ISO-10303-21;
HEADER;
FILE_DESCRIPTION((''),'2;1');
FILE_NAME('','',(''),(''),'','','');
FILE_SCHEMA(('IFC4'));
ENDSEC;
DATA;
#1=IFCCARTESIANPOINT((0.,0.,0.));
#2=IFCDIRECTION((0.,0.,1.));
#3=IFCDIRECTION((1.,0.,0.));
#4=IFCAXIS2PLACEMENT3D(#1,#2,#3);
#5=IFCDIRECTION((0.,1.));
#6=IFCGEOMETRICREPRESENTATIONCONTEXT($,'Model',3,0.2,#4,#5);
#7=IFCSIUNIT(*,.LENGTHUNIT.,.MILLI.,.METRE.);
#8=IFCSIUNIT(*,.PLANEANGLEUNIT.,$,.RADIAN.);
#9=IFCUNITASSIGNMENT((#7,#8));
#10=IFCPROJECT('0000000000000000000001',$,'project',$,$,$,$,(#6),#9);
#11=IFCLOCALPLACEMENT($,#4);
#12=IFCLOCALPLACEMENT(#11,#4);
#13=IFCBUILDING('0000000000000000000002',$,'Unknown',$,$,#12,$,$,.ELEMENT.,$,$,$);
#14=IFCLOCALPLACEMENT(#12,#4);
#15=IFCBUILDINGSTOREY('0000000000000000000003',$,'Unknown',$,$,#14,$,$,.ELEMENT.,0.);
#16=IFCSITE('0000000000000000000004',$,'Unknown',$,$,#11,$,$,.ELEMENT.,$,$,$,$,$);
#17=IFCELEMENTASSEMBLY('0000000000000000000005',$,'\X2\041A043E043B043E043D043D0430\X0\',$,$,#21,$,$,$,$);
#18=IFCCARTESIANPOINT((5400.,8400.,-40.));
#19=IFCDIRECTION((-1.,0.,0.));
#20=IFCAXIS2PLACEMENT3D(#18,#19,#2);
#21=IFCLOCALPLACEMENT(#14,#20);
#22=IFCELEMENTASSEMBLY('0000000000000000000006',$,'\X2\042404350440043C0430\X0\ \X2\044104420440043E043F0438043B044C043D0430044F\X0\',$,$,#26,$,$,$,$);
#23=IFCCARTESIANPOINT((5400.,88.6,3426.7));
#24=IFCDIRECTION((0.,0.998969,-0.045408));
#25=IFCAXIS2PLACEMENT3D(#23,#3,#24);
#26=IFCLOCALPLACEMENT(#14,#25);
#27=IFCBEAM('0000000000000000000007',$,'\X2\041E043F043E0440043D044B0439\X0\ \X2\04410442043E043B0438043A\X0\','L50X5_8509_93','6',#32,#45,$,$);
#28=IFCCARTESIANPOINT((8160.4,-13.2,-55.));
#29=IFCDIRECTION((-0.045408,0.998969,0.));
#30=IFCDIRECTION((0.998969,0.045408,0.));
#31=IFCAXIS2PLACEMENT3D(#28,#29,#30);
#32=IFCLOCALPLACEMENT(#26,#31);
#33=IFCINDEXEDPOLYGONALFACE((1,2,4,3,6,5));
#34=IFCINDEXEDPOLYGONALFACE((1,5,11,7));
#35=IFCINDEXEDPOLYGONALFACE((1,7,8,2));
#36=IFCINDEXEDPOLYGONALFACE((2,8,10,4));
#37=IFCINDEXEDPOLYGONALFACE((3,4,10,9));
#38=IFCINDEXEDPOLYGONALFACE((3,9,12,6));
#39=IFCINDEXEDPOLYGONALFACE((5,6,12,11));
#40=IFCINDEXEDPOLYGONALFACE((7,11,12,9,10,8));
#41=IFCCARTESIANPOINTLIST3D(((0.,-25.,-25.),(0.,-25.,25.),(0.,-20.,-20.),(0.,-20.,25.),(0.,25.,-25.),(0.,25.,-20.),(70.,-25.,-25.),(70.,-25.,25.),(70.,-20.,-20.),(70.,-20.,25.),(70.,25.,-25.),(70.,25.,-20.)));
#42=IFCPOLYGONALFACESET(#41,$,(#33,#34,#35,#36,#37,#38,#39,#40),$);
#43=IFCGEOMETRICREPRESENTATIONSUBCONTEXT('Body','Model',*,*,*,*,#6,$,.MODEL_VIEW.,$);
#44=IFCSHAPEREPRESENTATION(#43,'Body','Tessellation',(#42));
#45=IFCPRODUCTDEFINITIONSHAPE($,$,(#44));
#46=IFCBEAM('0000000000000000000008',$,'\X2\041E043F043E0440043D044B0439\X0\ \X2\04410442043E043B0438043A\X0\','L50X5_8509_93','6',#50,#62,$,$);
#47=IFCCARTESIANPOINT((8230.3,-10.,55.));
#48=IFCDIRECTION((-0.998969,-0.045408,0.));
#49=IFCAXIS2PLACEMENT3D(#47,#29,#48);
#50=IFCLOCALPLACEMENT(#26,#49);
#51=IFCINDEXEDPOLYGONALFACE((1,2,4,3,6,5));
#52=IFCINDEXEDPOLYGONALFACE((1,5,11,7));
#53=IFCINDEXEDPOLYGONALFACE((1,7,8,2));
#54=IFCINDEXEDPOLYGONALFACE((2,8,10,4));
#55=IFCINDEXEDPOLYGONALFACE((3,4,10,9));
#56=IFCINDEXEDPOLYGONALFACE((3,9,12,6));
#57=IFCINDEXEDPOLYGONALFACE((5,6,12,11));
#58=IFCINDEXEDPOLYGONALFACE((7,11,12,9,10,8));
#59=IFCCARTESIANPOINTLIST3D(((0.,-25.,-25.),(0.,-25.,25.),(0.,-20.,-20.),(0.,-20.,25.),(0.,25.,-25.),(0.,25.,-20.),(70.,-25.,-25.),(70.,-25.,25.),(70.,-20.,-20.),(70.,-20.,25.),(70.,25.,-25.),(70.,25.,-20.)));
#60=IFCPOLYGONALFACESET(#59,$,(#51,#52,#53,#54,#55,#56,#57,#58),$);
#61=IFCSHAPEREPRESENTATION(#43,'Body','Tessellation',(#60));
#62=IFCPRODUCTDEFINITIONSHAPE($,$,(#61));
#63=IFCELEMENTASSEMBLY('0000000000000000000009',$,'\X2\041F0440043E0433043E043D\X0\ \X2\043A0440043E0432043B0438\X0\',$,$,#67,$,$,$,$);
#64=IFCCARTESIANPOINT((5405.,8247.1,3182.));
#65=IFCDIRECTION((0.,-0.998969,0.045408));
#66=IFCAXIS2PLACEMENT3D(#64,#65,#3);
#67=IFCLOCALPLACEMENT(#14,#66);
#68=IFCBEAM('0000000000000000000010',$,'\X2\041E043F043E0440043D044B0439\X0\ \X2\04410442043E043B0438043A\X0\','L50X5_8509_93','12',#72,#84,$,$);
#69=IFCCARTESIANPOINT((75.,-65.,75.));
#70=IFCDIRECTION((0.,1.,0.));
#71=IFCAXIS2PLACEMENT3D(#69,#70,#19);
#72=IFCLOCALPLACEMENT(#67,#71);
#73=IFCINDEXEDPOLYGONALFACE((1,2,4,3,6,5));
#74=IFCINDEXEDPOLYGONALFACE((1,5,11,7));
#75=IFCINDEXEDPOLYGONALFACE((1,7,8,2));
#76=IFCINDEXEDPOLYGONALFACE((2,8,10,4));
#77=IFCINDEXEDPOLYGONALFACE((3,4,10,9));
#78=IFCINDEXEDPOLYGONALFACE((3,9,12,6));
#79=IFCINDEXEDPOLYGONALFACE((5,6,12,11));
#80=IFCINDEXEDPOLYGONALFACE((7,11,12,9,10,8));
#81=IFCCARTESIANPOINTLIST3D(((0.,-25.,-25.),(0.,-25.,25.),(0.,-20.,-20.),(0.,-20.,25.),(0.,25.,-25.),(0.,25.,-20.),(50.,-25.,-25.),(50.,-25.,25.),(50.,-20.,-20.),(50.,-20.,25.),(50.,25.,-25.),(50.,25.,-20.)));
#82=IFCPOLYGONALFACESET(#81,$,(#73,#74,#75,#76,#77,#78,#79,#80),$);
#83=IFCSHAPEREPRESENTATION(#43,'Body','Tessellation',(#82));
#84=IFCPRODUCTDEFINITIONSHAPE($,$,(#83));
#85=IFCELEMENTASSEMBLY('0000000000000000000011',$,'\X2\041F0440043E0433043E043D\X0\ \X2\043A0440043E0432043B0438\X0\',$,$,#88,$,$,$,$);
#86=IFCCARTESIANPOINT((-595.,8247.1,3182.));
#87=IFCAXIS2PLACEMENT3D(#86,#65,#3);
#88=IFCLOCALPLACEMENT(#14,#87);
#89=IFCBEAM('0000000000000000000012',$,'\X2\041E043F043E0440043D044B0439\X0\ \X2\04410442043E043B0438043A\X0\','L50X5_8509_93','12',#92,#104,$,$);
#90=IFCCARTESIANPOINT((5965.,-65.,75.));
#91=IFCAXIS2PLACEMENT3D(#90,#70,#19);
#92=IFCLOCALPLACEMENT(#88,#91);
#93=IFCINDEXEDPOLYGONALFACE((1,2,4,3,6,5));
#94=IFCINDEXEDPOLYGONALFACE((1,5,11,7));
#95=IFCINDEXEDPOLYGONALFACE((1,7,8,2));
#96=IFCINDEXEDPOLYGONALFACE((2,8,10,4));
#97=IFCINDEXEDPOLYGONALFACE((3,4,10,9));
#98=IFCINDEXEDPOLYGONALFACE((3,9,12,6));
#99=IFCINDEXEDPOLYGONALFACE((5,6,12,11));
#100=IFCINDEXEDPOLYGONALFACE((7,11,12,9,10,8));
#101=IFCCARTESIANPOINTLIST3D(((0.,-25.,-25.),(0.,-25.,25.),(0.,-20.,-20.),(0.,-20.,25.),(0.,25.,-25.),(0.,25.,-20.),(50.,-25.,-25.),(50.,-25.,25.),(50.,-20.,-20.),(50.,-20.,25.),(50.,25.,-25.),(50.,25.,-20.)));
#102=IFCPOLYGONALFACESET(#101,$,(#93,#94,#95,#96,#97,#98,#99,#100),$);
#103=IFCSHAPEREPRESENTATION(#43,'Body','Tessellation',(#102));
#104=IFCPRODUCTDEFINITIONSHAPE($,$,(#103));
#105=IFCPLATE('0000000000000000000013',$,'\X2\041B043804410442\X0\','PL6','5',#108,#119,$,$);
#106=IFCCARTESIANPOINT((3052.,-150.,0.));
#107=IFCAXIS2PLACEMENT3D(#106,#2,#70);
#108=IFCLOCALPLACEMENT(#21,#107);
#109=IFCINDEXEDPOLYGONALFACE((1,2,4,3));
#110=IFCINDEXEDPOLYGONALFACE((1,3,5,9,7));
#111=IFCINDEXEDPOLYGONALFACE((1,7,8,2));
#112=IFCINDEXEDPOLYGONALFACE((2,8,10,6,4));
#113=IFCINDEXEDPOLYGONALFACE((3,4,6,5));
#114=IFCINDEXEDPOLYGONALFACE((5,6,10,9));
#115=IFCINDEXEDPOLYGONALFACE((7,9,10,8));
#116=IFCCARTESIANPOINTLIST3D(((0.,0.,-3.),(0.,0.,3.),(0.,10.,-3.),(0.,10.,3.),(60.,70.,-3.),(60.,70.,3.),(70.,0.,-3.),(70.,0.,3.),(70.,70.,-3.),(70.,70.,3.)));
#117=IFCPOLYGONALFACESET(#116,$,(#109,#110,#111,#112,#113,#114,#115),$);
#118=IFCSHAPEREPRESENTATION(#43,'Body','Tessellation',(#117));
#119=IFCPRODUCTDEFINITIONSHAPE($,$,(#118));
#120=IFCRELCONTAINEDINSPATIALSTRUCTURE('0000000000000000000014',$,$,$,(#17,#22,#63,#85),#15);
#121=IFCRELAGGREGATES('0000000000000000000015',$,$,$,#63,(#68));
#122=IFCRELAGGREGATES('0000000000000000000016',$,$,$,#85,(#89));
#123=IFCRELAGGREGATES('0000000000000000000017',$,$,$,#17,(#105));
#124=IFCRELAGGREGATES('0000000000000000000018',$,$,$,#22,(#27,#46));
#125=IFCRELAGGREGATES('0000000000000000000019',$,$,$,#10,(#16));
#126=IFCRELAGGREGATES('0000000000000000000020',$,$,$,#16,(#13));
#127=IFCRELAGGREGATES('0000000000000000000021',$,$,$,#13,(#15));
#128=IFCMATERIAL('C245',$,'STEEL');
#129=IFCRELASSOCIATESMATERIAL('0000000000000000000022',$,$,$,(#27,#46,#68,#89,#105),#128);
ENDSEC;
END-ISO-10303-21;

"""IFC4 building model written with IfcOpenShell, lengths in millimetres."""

from ifc_helpers import new_model, si_unit, direction, frame, origin_with_axes, place, context, subcontext, project, spatial, line, indexed_curve, outline, extrude, material, element, aggregate, save


model = new_model("IFC4")

# Units and contexts
model_context = context("Model", 3, precision=0.2, world=origin_with_axes(), true_north=direction((0.0, 1.0)))
body_context = subcontext(model_context, "Body", "Model", "MODEL_VIEW")
ifc_project = project(units=[si_unit("LENGTHUNIT", "METRE", prefix="MILLI"), si_unit("PLANEANGLEUNIT", "RADIAN")], contexts=[model_context])

# Site, building, storey
site_placement = place(None, origin_with_axes())
site = spatial("IfcSite", under=ifc_project, at=site_placement, Name="Unknown", CompositionType="ELEMENT")
building_placement = place(site_placement, origin_with_axes())
building = spatial("IfcBuilding", under=site, at=building_placement, Name="Unknown", CompositionType="ELEMENT")
storey_placement = place(building_placement, origin_with_axes())
storey = spatial("IfcBuildingStorey", under=building, at=storey_placement, Name="Unknown", CompositionType="ELEMENT", Elevation=0.0)

# Shared definitions
ifc_material_1 = material(Name="C245", Category="STEEL")

# Element assembly
assembly_1_placement = place(storey_placement, frame((5400.0, 8400.0, -40.0), z_axis=(-1.0, 0.0, 0.0), x_axis=(0.0, 0.0, 1.0)))
assembly_1 = element("IfcElementAssembly", 1, at=assembly_1_placement, inside=storey, Name="Колонна")

# Element assembly, beams
assembly_2_placement = place(storey_placement, frame((5400.0, 88.6, 3426.7), z_axis=(1.0, 0.0, 0.0), x_axis=(0.0, 0.998969, -0.045408)))
assembly_2 = element("IfcElementAssembly", 2, at=assembly_2_placement, inside=storey, Name="Ферма стропильная")
beam_1_placement = place(assembly_2_placement, frame((8160.4, -13.2, -55.0), z_axis=(-0.045408, 0.998969, 0.0), x_axis=(0.998969, 0.045408, 0.0)))
beam_1 = element("IfcBeam", 3, at=beam_1_placement, material=ifc_material_1, Name="Опорный столик", Description="L50X5_8509_93", ObjectType="6", context=body_context, shape_type="SolidModel", body=[
    extrude(outline(indexed_curve([(-25.0, -25.0), (25.0, -25.0), (25.0, -20.0), (-20.0, -20.0), (-20.0, 25.0), (-25.0, 25.0)], segments=[line(1, 2, 3, 4, 5, 6, 1)])), frame((0.0, 0.0, 0.0), z_axis=(-1.0, 0.0, 0.0), x_axis=(0.0, 0.0, 1.0)), (0.0, 0.0, -1.0), 70.0),
])
beam_2_placement = place(assembly_2_placement, frame((8230.3, -10.0, 55.0), z_axis=(-0.045408, 0.998969, 0.0), x_axis=(-0.998969, -0.045408, 0.0)))
beam_2 = element("IfcBeam", 4, at=beam_2_placement, material=ifc_material_1, Name="Опорный столик", Description="L50X5_8509_93", ObjectType="6", context=body_context, shape_type="SolidModel", body=[
    extrude(outline(indexed_curve([(-25.0, -25.0), (25.0, -25.0), (25.0, -20.0), (-20.0, -20.0), (-20.0, 25.0), (-25.0, 25.0)], segments=[line(1, 2, 3, 4, 5, 6, 1)])), frame((0.0, 0.0, 0.0), z_axis=(-1.0, 0.0, 0.0), x_axis=(0.0, 0.0, 1.0)), (0.0, 0.0, -1.0), 70.0),
])

# Element assembly, beam
assembly_3_placement = place(storey_placement, frame((5405.0, 8247.1, 3182.0), z_axis=(0.0, -0.998969, 0.045408), x_axis=(1.0, 0.0, 0.0)))
assembly_3 = element("IfcElementAssembly", 5, at=assembly_3_placement, inside=storey, Name="Прогон кровли")
beam_3_placement = place(assembly_3_placement, frame((75.0, -65.0, 75.0), z_axis=(0.0, 1.0, 0.0), x_axis=(-1.0, 0.0, 0.0)))
beam_3 = element("IfcBeam", 6, at=beam_3_placement, material=ifc_material_1, Name="Опорный столик", Description="L50X5_8509_93", ObjectType="12", context=body_context, shape_type="SolidModel", body=[
    extrude(outline(indexed_curve([(-25.0, -25.0), (25.0, -25.0), (25.0, -20.0), (-20.0, -20.0), (-20.0, 25.0), (-25.0, 25.0)], segments=[line(1, 2, 3, 4, 5, 6, 1)])), frame((0.0, 0.0, 0.0), z_axis=(-1.0, 0.0, 0.0), x_axis=(0.0, 0.0, 1.0)), (0.0, 0.0, -1.0), 50.0),
])

# Element assembly, beam
assembly_4_placement = place(storey_placement, frame((-595.0, 8247.1, 3182.0), z_axis=(0.0, -0.998969, 0.045408), x_axis=(1.0, 0.0, 0.0)))
assembly_4 = element("IfcElementAssembly", 7, at=assembly_4_placement, inside=storey, Name="Прогон кровли")
beam_4_placement = place(assembly_4_placement, frame((5965.0, -65.0, 75.0), z_axis=(0.0, 1.0, 0.0), x_axis=(-1.0, 0.0, 0.0)))
beam_4 = element("IfcBeam", 8, at=beam_4_placement, material=ifc_material_1, Name="Опорный столик", Description="L50X5_8509_93", ObjectType="12", context=body_context, shape_type="SolidModel", body=[
    extrude(outline(indexed_curve([(-25.0, -25.0), (25.0, -25.0), (25.0, -20.0), (-20.0, -20.0), (-20.0, 25.0), (-25.0, 25.0)], segments=[line(1, 2, 3, 4, 5, 6, 1)])), frame((0.0, 0.0, 0.0), z_axis=(-1.0, 0.0, 0.0), x_axis=(0.0, 0.0, 1.0)), (0.0, 0.0, -1.0), 50.0),
])

# Plate
plate_1_placement = place(assembly_1_placement, frame((3052.0, -150.0, 0.0), z_axis=(0.0, 0.0, 1.0), x_axis=(0.0, 1.0, 0.0)))
plate_1 = element("IfcPlate", 9, at=plate_1_placement, material=ifc_material_1, Name="Лист", Description="PL6", ObjectType="5", context=body_context, shape_type="SolidModel", body=[
    extrude(outline(indexed_curve([(0.0, 0.0), (70.0, 0.0), (70.0, 70.0), (60.0, 70.0), (0.0, 10.0)], segments=[line(1, 2, 3, 4, 5, 1)])), frame((0.0, 0.0, 3.0), z_axis=(0.0, 0.0, 1.0), x_axis=(1.0, 0.0, 0.0)), (0.0, 0.0, -1.0), 6.0),
])
aggregate(assembly_3, [beam_3])
aggregate(assembly_4, [beam_4])

aggregate(assembly_1, [plate_1])
aggregate(assembly_2, [beam_1, beam_2])

save(model, "model.ifc")
